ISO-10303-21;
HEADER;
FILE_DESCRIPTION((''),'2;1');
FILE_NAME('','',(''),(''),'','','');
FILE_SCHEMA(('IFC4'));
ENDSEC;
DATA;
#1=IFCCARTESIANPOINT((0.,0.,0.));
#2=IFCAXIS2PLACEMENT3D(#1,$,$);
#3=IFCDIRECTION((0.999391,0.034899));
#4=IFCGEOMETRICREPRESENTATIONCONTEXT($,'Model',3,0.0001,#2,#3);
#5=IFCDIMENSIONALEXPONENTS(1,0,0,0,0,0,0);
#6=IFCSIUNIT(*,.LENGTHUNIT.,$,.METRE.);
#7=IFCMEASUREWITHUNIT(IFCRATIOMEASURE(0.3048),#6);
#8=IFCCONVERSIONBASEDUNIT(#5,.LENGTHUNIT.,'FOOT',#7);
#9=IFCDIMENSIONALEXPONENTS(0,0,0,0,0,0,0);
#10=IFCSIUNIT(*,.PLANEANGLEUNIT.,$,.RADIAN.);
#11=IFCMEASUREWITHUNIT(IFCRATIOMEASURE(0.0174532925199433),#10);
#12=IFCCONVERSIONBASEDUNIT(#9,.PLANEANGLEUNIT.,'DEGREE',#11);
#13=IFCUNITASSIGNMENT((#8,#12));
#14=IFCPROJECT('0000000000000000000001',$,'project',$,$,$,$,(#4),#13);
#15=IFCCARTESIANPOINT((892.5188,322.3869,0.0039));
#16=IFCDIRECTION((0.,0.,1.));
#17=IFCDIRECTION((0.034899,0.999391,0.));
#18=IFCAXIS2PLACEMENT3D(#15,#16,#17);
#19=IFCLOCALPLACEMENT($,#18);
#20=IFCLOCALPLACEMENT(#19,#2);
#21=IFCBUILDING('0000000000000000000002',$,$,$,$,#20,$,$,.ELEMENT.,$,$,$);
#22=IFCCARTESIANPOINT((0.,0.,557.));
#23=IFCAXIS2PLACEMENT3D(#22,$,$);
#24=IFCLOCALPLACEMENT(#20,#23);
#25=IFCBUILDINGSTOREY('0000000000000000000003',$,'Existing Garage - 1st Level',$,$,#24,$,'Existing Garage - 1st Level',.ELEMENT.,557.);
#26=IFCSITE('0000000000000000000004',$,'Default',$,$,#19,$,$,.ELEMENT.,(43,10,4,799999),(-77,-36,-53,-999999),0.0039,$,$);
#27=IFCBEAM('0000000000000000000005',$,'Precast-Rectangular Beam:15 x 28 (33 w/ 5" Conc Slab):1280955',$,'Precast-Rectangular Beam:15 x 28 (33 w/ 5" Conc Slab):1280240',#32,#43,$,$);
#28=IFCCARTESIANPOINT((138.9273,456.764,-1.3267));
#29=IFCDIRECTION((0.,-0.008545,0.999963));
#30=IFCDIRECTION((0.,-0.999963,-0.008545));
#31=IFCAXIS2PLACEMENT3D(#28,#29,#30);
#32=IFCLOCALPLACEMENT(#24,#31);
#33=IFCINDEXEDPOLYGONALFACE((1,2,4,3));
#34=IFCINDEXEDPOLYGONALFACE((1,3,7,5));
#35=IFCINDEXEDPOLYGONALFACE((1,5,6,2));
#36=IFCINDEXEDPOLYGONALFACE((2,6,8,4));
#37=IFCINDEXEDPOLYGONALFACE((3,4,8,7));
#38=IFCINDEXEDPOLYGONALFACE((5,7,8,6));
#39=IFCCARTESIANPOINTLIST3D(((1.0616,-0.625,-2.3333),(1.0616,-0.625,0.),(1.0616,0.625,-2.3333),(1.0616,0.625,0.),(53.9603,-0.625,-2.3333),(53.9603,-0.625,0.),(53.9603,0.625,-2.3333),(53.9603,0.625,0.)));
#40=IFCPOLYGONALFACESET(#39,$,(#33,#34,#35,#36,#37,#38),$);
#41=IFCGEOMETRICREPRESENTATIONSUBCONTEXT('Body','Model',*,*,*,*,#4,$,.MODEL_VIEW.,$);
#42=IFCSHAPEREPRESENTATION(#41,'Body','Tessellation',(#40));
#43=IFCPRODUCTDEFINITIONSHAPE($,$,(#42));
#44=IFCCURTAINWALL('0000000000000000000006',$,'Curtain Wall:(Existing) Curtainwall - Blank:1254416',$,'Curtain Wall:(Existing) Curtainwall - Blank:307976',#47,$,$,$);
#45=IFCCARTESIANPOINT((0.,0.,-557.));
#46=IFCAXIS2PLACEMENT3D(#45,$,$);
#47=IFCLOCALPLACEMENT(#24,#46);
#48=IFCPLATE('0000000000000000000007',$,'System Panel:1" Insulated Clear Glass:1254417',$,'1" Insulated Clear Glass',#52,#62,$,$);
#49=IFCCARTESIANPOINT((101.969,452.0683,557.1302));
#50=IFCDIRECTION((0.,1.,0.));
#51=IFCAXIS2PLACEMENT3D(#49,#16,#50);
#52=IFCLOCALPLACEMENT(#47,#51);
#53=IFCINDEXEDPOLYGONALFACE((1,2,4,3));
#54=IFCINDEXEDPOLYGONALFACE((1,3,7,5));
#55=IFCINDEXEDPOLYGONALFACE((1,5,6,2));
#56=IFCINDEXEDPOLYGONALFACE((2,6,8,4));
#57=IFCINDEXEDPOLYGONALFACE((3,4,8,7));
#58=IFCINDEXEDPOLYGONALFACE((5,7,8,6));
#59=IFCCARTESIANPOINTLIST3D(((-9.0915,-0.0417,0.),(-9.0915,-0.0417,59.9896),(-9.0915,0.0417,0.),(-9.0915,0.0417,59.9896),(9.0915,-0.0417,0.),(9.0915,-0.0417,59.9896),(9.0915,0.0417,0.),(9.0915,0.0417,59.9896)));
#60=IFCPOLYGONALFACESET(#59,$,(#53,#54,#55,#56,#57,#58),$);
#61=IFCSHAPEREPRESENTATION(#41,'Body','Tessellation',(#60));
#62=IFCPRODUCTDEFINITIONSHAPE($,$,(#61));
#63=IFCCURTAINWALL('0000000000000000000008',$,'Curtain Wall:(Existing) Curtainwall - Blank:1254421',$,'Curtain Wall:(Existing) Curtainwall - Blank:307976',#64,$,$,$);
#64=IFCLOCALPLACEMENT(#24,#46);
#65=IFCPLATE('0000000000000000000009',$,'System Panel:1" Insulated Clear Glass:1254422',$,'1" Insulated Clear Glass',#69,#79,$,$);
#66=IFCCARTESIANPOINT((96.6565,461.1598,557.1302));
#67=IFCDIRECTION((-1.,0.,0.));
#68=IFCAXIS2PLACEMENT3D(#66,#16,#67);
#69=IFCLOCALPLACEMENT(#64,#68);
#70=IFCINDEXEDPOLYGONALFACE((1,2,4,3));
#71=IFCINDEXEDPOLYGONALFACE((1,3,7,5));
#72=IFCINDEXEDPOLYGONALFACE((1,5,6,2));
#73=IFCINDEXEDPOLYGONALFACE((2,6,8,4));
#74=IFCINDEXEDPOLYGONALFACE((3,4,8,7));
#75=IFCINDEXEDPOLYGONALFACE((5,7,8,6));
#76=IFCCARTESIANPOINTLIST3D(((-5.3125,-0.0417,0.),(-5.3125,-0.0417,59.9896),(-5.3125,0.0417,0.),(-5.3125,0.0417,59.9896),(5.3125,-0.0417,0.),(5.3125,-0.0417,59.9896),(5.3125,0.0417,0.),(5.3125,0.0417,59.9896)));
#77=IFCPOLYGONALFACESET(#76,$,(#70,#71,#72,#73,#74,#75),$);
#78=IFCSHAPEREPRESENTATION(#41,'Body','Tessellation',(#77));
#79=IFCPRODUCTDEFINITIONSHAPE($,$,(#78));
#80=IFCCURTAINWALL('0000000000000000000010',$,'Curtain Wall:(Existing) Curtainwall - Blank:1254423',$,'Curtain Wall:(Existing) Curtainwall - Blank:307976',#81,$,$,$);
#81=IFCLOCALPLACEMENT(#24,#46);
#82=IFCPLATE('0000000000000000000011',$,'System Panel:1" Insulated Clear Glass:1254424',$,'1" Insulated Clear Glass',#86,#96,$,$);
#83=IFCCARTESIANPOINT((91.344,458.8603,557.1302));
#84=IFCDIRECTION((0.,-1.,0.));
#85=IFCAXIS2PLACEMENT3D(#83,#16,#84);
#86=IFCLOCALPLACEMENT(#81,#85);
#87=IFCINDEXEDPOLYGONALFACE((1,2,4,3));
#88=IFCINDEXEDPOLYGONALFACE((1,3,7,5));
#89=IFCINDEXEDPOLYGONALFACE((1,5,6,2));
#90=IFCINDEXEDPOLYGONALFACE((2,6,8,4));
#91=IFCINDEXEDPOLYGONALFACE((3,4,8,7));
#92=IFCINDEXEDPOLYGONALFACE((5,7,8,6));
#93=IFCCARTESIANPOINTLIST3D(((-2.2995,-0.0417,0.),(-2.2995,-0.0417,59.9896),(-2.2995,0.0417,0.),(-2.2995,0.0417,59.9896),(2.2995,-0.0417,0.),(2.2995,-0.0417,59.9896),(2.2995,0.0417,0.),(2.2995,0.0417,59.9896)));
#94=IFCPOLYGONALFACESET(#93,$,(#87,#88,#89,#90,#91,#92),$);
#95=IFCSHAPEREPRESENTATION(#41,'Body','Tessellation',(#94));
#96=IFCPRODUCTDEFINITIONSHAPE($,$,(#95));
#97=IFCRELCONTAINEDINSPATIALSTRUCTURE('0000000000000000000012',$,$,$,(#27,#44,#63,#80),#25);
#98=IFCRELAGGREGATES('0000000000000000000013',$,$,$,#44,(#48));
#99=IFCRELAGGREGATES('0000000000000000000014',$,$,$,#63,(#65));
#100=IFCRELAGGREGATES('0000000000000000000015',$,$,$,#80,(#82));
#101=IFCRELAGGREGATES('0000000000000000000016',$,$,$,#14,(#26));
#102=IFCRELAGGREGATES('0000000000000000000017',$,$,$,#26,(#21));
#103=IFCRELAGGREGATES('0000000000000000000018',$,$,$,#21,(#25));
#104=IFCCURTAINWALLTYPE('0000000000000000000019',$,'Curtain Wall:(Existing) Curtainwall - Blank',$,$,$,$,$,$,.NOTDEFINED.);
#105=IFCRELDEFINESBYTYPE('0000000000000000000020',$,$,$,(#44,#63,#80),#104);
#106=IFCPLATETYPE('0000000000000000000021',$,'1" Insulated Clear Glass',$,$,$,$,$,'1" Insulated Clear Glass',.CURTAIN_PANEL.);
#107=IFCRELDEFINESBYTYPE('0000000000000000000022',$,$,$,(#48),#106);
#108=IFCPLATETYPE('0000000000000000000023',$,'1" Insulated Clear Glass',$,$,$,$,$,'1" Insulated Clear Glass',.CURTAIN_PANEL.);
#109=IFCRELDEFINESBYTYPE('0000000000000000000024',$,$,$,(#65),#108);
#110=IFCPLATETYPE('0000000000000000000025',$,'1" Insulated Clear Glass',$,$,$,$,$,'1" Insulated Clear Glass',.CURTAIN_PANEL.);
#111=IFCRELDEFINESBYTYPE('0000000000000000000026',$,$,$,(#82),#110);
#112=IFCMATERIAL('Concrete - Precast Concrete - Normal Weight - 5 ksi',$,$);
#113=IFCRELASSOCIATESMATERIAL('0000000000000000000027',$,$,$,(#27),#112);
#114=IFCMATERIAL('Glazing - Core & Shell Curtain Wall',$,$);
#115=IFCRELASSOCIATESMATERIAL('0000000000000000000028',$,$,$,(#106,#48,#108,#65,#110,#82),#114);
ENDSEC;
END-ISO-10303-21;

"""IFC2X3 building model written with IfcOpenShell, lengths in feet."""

from ifc_helpers import new_model, entity, si_unit, converted_unit, direction, frame, frame_2d, origin, origin_2d_with_axis, place, context, subcontext, project, spatial, rectangle, extrude, source, transform, mapped, material, type_object, type_shapes, element, aggregate, save


model = new_model("IFC2X3")

# Units and contexts
model_context = context("Model", 3, precision=0.0001, world=origin(), true_north=direction((0.999391, 0.034899)))
body_context = subcontext(model_context, "Body", "Model", "MODEL_VIEW")
ifc_project = project(units=[converted_unit("LENGTHUNIT", "FOOT", entity("IfcRatioMeasure", 0.3048), si_unit("LENGTHUNIT", "METRE"), dimensions=[1, 0, 0, 0, 0, 0, 0]), converted_unit("PLANEANGLEUNIT", "DEGREE", entity("IfcRatioMeasure", 0.0174532925199433), si_unit("PLANEANGLEUNIT", "RADIAN"), dimensions=[0, 0, 0, 0, 0, 0, 0])], contexts=[model_context])

# Site, building, storey
site_placement = place(None, frame((892.5188, 322.3869, 0.0039), z_axis=(0.0, 0.0, 1.0), x_axis=(0.034899, 0.999391, 0.0)))
site = spatial("IfcSite", under=ifc_project, at=site_placement, Name="Default", CompositionType="ELEMENT", RefLatitude=(43, 10, 4, 799999), RefLongitude=(-77, -36, -53, -999999), RefElevation=0.0039)
building_placement = place(site_placement, origin())
building = spatial("IfcBuilding", under=site, at=building_placement, CompositionType="ELEMENT")
storey_placement = place(building_placement, frame((0.0, 0.0, 557.0)))
storey = spatial("IfcBuildingStorey", under=building, at=storey_placement, Name="Existing Garage - 1st Level", LongName="Existing Garage - 1st Level", CompositionType="ELEMENT", Elevation=557.0)

# Beam
ifc_material_1 = material(Name="Concrete - Precast Concrete - Normal Weight - 5 ksi")
beam_1_placement = place(storey_placement, frame((138.9273, 456.764, -1.3267), z_axis=(0.0, -0.008545, 0.999963), x_axis=(0.0, -0.999963, -0.008545)))
element("IfcBeam", 1, at=beam_1_placement, inside=storey, material=ifc_material_1, Name="Precast-Rectangular Beam:15 x 28 (33 w/ 5\" Conc Slab):1280955", ObjectType="Precast-Rectangular Beam:15 x 28 (33 w/ 5\" Conc Slab):1280240", context=body_context, shape_type="SweptSolid", body=[
    extrude(rectangle(XDim=2.3333, YDim=1.25, at=frame_2d((0.0, 0.0), x_axis=(1.0, 0.0))), frame((1.0616, 0.0, -1.1667), z_axis=(1.0, 0.0, 0.0), x_axis=(0.0, 0.0, -1.0)), (0.0, 0.0, 1.0), 52.8987),
])

# Curtain walls, plates
curtain_wall_type = type_object("IfcCurtainWallType", Name="Curtain Wall:(Existing) Curtainwall - Blank", PredefinedType="NOTDEFINED")
curtain_wall_1_placement = place(storey_placement, frame((0.0, 0.0, -557.0)))
curtain_wall_1 = element("IfcCurtainWall", 2, at=curtain_wall_1_placement, inside=storey, type_object=curtain_wall_type, Name="Curtain Wall:(Existing) Curtainwall - Blank:1254416", ObjectType="Curtain Wall:(Existing) Curtainwall - Blank:307976")
ifc_material_2 = material(Name="Glazing - Core & Shell Curtain Wall")
plate_type_1 = type_object("IfcPlateType", Name="1\" Insulated Clear Glass", ElementType="1\" Insulated Clear Glass", PredefinedType="CURTAIN_PANEL", material=ifc_material_2)
shared_shape_1 = source(origin(), body_context, "Body", "SweptSolid", [
    extrude(rectangle(XDim=0.0833, YDim=18.1831, at=origin_2d_with_axis()), frame((0.0, 0.0, 0.0), z_axis=(0.0, 0.0, 1.0), x_axis=(0.0, 1.0, 0.0)), (0.0, 0.0, 1.0), 59.9896),
])
type_shapes(plate_type_1, [shared_shape_1])
plate_1_placement = place(curtain_wall_1_placement, frame((101.969, 452.0683, 557.1302), z_axis=(0.0, 0.0, 1.0), x_axis=(0.0, 1.0, 0.0)))
plate_1 = element("IfcPlate", 3, at=plate_1_placement, type_object=plate_type_1, material=ifc_material_2, Name="System Panel:1\" Insulated Clear Glass:1254417", ObjectType="1\" Insulated Clear Glass", context=body_context, shape_type="MappedRepresentation", body=[
    mapped(shared_shape_1, transform((0.0, 0.0, 0.0), scale=1.0)),
])
aggregate(curtain_wall_1, [plate_1])
curtain_wall_2_placement = place(storey_placement, frame((0.0, 0.0, -557.0)))
curtain_wall_2 = element("IfcCurtainWall", 4, at=curtain_wall_2_placement, inside=storey, type_object=curtain_wall_type, Name="Curtain Wall:(Existing) Curtainwall - Blank:1254421", ObjectType="Curtain Wall:(Existing) Curtainwall - Blank:307976")
plate_type_2 = type_object("IfcPlateType", Name="1\" Insulated Clear Glass", ElementType="1\" Insulated Clear Glass", PredefinedType="CURTAIN_PANEL", material=ifc_material_2)
shared_shape_2 = source(origin(), body_context, "Body", "SweptSolid", [
    extrude(rectangle(XDim=0.0833, YDim=10.625, at=origin_2d_with_axis()), frame((0.0, 0.0, 0.0), z_axis=(0.0, 0.0, 1.0), x_axis=(0.0, 1.0, 0.0)), (0.0, 0.0, 1.0), 59.9896),
])
type_shapes(plate_type_2, [shared_shape_2])
plate_2_placement = place(curtain_wall_2_placement, frame((96.6565, 461.1598, 557.1302), z_axis=(0.0, 0.0, 1.0), x_axis=(-1.0, 0.0, 0.0)))
plate_2 = element("IfcPlate", 5, at=plate_2_placement, type_object=plate_type_2, material=ifc_material_2, Name="System Panel:1\" Insulated Clear Glass:1254422", ObjectType="1\" Insulated Clear Glass", context=body_context, shape_type="MappedRepresentation", body=[
    mapped(shared_shape_2, transform((0.0, 0.0, 0.0), scale=1.0)),
])
aggregate(curtain_wall_2, [plate_2])
curtain_wall_3_placement = place(storey_placement, frame((0.0, 0.0, -557.0)))
curtain_wall_3 = element("IfcCurtainWall", 6, at=curtain_wall_3_placement, inside=storey, type_object=curtain_wall_type, Name="Curtain Wall:(Existing) Curtainwall - Blank:1254423", ObjectType="Curtain Wall:(Existing) Curtainwall - Blank:307976")
plate_type_3 = type_object("IfcPlateType", Name="1\" Insulated Clear Glass", ElementType="1\" Insulated Clear Glass", PredefinedType="CURTAIN_PANEL", material=ifc_material_2)
shared_shape_3 = source(origin(), body_context, "Body", "SweptSolid", [
    extrude(rectangle(XDim=0.0833, YDim=4.599, at=origin_2d_with_axis()), frame((0.0, 0.0, 0.0), z_axis=(0.0, 0.0, 1.0), x_axis=(0.0, 1.0, 0.0)), (0.0, 0.0, 1.0), 59.9896),
])
type_shapes(plate_type_3, [shared_shape_3])
plate_3_placement = place(curtain_wall_3_placement, frame((91.344, 458.8603, 557.1302), z_axis=(0.0, 0.0, 1.0), x_axis=(0.0, -1.0, 0.0)))
plate_3 = element("IfcPlate", 7, at=plate_3_placement, type_object=plate_type_3, material=ifc_material_2, Name="System Panel:1\" Insulated Clear Glass:1254424", ObjectType="1\" Insulated Clear Glass", context=body_context, shape_type="MappedRepresentation", body=[
    mapped(shared_shape_3, transform((0.0, 0.0, 0.0), scale=1.0)),
])
aggregate(curtain_wall_3, [plate_3])

save(model, "model.ifc")
